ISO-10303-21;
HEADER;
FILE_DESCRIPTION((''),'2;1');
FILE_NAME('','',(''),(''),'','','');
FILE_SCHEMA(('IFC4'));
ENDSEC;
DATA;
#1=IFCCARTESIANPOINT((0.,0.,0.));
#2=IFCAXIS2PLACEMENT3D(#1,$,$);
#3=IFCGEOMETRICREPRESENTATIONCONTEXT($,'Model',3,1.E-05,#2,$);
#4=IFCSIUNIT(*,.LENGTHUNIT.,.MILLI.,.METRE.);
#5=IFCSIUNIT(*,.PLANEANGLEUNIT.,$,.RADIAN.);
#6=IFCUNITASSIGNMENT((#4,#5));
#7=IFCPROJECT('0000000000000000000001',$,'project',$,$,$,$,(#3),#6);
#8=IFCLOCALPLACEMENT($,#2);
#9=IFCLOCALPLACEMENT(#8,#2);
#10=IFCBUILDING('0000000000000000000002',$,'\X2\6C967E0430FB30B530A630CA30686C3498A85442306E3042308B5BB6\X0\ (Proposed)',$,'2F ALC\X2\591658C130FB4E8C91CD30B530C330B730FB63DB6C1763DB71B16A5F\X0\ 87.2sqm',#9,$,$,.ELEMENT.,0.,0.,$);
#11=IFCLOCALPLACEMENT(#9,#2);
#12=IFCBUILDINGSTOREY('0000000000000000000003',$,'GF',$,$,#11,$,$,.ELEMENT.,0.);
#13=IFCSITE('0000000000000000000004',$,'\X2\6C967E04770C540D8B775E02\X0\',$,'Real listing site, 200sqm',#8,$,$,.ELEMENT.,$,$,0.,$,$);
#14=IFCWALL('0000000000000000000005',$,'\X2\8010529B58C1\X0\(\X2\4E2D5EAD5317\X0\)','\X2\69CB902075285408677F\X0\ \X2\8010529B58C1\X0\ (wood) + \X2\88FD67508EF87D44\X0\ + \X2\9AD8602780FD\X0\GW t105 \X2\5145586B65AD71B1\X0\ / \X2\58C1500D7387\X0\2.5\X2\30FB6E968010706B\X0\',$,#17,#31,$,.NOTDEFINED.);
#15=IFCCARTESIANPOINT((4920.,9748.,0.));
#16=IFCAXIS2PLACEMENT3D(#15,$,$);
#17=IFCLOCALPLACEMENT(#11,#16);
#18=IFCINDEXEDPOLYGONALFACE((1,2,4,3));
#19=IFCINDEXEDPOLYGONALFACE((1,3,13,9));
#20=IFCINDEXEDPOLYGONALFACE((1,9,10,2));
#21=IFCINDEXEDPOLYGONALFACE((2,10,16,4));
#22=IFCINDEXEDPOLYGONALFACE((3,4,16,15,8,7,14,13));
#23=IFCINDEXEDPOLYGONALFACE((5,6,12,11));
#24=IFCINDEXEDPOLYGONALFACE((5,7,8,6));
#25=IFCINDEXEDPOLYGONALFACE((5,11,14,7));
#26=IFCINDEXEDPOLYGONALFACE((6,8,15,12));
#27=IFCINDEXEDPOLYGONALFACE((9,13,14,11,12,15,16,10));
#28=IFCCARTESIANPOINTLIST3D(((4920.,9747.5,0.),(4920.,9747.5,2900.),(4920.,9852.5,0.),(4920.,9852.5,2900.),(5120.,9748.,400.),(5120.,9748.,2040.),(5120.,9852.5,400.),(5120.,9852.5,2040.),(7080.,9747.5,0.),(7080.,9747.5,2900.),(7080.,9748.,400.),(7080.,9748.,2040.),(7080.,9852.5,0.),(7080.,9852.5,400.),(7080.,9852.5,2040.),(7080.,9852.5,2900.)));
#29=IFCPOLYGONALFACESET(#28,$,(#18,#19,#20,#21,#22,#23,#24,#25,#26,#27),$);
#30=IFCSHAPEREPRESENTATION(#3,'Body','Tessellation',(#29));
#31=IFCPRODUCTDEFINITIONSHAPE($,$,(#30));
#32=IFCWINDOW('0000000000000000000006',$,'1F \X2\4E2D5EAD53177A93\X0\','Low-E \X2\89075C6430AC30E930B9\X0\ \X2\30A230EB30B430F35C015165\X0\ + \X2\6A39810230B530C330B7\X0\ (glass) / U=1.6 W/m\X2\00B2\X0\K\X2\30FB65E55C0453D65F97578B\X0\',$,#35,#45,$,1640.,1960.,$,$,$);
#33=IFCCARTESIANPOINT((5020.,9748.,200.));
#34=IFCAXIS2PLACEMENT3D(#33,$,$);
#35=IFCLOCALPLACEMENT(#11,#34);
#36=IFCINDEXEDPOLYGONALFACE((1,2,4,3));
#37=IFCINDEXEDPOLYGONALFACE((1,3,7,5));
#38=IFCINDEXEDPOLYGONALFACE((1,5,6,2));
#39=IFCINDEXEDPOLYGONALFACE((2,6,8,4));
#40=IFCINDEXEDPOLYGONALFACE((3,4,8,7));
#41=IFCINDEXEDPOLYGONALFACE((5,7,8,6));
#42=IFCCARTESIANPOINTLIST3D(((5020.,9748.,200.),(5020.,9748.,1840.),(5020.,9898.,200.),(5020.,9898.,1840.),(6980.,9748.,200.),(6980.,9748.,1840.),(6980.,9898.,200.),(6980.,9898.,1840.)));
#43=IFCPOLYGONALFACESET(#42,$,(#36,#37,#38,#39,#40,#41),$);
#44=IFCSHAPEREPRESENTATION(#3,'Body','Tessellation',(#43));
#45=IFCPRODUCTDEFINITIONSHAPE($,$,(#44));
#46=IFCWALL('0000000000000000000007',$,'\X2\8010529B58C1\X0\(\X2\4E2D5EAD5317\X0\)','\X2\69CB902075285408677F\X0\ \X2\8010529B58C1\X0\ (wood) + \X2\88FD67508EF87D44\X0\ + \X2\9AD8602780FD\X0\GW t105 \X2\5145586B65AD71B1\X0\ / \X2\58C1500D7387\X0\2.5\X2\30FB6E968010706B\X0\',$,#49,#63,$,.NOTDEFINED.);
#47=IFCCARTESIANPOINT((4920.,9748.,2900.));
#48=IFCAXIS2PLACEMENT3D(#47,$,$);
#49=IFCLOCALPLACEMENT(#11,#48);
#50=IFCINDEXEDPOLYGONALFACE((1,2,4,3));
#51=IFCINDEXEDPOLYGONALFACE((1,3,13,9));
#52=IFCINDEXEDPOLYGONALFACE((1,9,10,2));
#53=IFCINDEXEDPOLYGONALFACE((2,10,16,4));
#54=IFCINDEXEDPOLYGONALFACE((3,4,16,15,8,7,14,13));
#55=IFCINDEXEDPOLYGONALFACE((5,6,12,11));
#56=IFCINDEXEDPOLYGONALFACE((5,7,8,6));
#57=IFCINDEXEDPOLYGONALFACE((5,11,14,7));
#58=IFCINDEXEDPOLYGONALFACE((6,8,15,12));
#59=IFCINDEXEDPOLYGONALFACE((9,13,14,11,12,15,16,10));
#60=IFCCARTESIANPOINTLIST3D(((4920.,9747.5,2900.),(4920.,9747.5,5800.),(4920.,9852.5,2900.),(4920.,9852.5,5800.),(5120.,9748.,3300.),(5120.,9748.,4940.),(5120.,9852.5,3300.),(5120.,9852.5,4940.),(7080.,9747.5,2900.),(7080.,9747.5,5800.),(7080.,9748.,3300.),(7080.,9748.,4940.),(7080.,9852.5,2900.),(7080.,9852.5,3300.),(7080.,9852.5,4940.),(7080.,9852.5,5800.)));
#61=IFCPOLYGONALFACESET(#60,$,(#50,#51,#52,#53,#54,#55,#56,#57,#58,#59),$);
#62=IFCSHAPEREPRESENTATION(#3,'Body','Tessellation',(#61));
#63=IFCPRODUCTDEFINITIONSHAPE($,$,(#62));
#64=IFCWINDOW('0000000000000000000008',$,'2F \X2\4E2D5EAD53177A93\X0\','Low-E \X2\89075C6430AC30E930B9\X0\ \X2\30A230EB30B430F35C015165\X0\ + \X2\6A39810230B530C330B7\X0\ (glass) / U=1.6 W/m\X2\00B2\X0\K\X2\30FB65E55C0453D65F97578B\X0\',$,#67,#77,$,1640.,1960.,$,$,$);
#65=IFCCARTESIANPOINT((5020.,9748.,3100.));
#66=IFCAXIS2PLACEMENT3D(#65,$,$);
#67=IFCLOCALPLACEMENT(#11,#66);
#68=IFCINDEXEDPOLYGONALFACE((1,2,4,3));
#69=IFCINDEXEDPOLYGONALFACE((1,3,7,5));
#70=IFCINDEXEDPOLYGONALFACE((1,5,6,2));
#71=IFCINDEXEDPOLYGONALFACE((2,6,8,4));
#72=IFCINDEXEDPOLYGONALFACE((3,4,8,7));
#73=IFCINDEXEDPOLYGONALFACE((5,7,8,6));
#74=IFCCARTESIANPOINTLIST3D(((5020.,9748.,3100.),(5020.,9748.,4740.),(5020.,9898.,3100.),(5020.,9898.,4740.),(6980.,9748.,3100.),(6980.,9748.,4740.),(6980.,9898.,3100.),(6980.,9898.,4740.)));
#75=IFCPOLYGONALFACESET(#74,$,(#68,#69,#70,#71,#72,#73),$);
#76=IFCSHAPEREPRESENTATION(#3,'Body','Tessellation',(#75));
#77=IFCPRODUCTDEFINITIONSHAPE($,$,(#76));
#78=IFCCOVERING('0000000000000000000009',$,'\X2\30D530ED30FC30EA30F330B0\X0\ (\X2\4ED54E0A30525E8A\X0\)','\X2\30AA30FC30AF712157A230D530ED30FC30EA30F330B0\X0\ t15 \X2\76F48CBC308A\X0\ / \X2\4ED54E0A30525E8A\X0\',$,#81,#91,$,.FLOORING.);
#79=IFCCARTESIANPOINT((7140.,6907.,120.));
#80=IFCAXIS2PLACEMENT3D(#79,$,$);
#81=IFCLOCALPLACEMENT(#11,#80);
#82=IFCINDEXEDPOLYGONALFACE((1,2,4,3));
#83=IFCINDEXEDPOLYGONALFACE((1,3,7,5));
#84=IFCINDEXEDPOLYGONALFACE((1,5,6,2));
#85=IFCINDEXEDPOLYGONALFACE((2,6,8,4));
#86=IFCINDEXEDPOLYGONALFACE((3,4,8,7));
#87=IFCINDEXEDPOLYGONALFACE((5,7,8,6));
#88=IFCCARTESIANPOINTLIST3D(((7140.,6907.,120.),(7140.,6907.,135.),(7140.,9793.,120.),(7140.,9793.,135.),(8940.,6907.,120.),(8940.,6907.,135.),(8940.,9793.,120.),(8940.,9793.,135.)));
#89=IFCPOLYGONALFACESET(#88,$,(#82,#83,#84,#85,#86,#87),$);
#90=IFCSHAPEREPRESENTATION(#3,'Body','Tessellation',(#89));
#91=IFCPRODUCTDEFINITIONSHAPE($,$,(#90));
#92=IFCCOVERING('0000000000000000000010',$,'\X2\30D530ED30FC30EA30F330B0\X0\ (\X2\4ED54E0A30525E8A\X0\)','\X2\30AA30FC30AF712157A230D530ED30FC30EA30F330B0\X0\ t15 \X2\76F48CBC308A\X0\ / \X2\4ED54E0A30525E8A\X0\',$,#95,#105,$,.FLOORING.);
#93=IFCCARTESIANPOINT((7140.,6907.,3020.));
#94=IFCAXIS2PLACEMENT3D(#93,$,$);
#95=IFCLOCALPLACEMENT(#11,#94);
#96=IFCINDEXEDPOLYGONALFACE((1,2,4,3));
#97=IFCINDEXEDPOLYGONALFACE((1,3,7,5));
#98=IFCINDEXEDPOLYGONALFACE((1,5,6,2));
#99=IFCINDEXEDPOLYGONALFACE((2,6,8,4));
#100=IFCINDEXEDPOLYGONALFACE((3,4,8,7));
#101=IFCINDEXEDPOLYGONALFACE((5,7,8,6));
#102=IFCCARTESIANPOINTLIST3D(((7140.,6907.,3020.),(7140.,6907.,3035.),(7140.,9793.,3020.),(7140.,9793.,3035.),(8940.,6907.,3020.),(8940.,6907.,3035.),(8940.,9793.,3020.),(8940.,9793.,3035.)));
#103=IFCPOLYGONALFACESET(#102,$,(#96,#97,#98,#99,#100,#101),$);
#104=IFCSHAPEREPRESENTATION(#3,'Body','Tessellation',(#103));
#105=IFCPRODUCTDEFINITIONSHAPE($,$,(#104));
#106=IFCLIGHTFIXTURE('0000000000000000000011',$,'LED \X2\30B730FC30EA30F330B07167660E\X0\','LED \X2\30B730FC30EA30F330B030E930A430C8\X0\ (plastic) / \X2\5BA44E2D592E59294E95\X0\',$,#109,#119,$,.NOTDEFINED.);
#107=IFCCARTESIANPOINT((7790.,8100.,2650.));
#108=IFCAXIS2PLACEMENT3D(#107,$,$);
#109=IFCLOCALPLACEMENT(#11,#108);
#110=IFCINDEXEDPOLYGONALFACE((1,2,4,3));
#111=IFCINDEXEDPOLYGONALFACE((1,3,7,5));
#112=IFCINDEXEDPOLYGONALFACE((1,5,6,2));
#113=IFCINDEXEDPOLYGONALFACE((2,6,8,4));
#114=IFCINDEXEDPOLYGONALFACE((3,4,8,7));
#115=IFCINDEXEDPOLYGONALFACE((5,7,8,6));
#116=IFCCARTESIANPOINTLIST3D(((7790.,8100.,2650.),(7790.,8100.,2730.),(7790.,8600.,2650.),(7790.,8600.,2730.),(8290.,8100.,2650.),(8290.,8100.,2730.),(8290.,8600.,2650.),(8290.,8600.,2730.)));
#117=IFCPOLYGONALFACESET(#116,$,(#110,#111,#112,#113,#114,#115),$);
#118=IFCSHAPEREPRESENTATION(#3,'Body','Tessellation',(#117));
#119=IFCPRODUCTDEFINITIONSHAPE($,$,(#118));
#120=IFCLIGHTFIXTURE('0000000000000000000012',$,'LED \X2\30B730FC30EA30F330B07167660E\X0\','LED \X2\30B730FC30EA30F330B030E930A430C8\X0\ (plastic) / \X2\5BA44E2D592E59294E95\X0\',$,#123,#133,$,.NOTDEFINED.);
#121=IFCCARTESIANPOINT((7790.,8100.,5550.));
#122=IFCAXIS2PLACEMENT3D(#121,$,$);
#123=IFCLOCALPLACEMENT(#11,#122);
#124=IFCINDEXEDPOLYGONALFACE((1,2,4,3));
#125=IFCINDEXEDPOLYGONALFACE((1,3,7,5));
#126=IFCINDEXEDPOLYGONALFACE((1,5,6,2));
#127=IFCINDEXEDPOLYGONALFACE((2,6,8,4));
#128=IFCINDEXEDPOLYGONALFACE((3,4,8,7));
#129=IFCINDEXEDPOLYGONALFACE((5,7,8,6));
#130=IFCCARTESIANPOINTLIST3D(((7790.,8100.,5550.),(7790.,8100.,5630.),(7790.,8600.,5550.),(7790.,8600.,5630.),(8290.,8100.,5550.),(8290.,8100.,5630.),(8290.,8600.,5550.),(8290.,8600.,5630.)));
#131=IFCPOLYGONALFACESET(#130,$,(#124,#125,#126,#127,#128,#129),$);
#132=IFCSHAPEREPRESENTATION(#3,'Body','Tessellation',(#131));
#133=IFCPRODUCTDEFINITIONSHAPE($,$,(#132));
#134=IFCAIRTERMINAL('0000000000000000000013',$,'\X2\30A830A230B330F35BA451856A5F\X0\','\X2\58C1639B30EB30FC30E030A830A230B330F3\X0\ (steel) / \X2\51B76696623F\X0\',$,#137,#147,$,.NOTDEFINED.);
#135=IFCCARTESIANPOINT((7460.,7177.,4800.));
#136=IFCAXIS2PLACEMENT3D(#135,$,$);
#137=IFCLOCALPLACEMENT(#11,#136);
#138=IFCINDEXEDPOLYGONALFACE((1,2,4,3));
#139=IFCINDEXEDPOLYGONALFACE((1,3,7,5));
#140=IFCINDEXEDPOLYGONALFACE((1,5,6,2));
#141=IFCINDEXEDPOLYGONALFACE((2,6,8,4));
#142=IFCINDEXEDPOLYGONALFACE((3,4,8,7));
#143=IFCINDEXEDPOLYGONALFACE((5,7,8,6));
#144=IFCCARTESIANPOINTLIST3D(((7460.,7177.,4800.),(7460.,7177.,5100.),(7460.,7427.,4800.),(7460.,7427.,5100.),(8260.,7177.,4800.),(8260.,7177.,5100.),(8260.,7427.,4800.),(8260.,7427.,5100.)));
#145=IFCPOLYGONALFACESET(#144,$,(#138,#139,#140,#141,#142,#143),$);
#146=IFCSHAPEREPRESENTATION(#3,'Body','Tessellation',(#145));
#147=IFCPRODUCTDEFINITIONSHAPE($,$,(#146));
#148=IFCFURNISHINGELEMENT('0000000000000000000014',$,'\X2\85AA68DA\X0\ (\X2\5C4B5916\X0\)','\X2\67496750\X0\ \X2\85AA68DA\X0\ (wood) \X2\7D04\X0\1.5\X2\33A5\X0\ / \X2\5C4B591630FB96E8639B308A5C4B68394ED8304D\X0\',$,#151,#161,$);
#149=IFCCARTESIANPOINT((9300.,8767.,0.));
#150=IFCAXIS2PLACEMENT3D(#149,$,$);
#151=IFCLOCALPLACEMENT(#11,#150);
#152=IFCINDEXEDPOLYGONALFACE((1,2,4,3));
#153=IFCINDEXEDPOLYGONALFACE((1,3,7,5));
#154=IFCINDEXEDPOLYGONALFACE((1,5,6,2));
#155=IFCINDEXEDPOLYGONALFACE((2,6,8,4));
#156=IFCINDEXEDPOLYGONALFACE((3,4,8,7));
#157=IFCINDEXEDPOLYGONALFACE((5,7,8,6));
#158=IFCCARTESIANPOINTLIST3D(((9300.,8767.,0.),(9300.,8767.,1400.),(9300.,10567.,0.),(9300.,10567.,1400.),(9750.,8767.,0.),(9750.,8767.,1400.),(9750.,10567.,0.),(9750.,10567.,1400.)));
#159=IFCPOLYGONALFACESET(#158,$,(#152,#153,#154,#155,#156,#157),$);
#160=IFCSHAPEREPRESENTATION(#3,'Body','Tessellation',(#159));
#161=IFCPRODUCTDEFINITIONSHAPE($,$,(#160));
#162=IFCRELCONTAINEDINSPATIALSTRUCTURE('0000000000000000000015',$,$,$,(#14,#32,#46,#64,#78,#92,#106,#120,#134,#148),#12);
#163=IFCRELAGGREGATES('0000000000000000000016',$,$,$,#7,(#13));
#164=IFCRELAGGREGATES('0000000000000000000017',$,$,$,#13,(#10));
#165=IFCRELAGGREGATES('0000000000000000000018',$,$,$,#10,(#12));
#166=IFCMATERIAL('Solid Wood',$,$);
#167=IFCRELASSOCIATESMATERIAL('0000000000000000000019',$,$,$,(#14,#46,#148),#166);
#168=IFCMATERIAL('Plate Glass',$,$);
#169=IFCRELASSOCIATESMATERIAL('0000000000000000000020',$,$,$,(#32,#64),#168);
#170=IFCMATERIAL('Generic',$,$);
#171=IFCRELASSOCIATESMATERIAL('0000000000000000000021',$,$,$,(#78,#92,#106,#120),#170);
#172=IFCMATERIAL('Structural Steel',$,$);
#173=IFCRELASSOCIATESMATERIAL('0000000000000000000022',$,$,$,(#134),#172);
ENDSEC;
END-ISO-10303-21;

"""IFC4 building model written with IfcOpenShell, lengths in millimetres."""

from ifc_helpers import new_model, si_unit, frame, frame_2d, origin, place, context, project, spatial, rectangle, extrude, material, element, fill, save


model = new_model("IFC4")

# Units and contexts
model_context = context("Model", 3, precision=1e-05, world=origin())
ifc_project = project(units=[si_unit("LENGTHUNIT", "METRE", prefix="MILLI"), si_unit("PLANEANGLEUNIT", "RADIAN")], contexts=[model_context])

# Site, building, storey
site_placement = place(None, origin())
site = spatial("IfcSite", under=ifc_project, at=site_placement, Name="沖縄県名護市", ObjectType="Real listing site, 200sqm", CompositionType="ELEMENT", RefElevation=0.0)
building_placement = place(site_placement, origin())
building = spatial("IfcBuilding", under=site, at=building_placement, Name="沖縄・サウナと水風呂のある家 (Proposed)", ObjectType="2F ALC外壁・二重サッシ・換気換熱機 87.2sqm", CompositionType="ELEMENT", ElevationOfRefHeight=0.0, ElevationOfTerrain=0.0)
storey_placement = place(building_placement, origin())
storey = spatial("IfcBuildingStorey", under=building, at=storey_placement, Name="GF", CompositionType="ELEMENT", Elevation=0.0)

# Shared definitions
ifc_material_1 = material(Name="Solid Wood")

# Walls, openings, windows
wall_1_placement = place(storey_placement, frame((4920.0, 9748.0, 0.0)))
wall_1 = element("IfcWall", 1, at=wall_1_placement, inside=storey, material=ifc_material_1, Name="耐力壁(中庭北)", Description="構造用合板 耐力壁 (wood) + 製材軸組 + 高性能GW t105 充填断熱 / 壁倍率2.5・準耐火", PredefinedType="NOTDEFINED", context=model_context, shape_type="SweptSolid", body=[
    extrude(rectangle(XDim=2160.0, YDim=105.0, at=frame_2d((1080.0, 52.0))), frame((4920.0, 9748.0, 0.0)), (0.0, 0.0, 1.0), 2900.0),
])
opening_1_placement = place(storey_placement, frame((5020.0, 9748.0, 200.0)))
opening_1 = element("IfcOpeningElement", 2, at=opening_1_placement, cuts=wall_1, PredefinedType="NOTDEFINED", context=model_context, shape_type="SweptSolid", body=[
    extrude(rectangle(XDim=1960.0, YDim=150.0, at=frame_2d((980.0, 75.0))), frame((5020.0, 9748.0, 200.0)), (0.0, 0.0, 1.0), 1640.0),
])
ifc_material_2 = material(Name="Plate Glass")
window_1_placement = place(storey_placement, frame((5020.0, 9748.0, 200.0)))
window_1 = element("IfcWindow", 3, at=window_1_placement, inside=storey, material=ifc_material_2, Name="1F 中庭北窓", Description="Low-E 複層ガラス アルゴン封入 + 樹脂サッシ (glass) / U=1.6 W/m²K・日射取得型", OverallHeight=1640.0, OverallWidth=1960.0, context=model_context, shape_type="SweptSolid", body=[
    extrude(rectangle(XDim=1960.0, YDim=150.0, at=frame_2d((980.0, 75.0))), frame((5020.0, 9748.0, 200.0)), (0.0, 0.0, 1.0), 1640.0),
])
fill(opening_1, window_1)
wall_2_placement = place(storey_placement, frame((4920.0, 9748.0, 2900.0)))
wall_2 = element("IfcWall", 4, at=wall_2_placement, inside=storey, material=ifc_material_1, Name="耐力壁(中庭北)", Description="構造用合板 耐力壁 (wood) + 製材軸組 + 高性能GW t105 充填断熱 / 壁倍率2.5・準耐火", PredefinedType="NOTDEFINED", context=model_context, shape_type="SweptSolid", body=[
    extrude(rectangle(XDim=2160.0, YDim=105.0, at=frame_2d((1080.0, 52.0))), frame((4920.0, 9748.0, 2900.0)), (0.0, 0.0, 1.0), 2900.0),
])
opening_2_placement = place(storey_placement, frame((5020.0, 9748.0, 3100.0)))
opening_2 = element("IfcOpeningElement", 5, at=opening_2_placement, cuts=wall_2, PredefinedType="NOTDEFINED", context=model_context, shape_type="SweptSolid", body=[
    extrude(rectangle(XDim=1960.0, YDim=150.0, at=frame_2d((980.0, 75.0))), frame((5020.0, 9748.0, 3100.0)), (0.0, 0.0, 1.0), 1640.0),
])
window_2_placement = place(storey_placement, frame((5020.0, 9748.0, 3100.0)))
window_2 = element("IfcWindow", 6, at=window_2_placement, inside=storey, material=ifc_material_2, Name="2F 中庭北窓", Description="Low-E 複層ガラス アルゴン封入 + 樹脂サッシ (glass) / U=1.6 W/m²K・日射取得型", OverallHeight=1640.0, OverallWidth=1960.0, context=model_context, shape_type="SweptSolid", body=[
    extrude(rectangle(XDim=1960.0, YDim=150.0, at=frame_2d((980.0, 75.0))), frame((5020.0, 9748.0, 3100.0)), (0.0, 0.0, 1.0), 1640.0),
])
fill(opening_2, window_2)

# Coverings
ifc_material_3 = material(Name="Generic")
covering_1_placement = place(storey_placement, frame((7140.0, 6907.0, 120.0)))
element("IfcCovering", 7, at=covering_1_placement, inside=storey, material=ifc_material_3, Name="フローリング (仕上げ床)", Description="オーク無垢フローリング t15 直貼り / 仕上げ床", PredefinedType="FLOORING", context=model_context, shape_type="SweptSolid", body=[
    extrude(rectangle(XDim=1800.0, YDim=2886.0, at=frame_2d((900.0, 1443.0))), frame((7140.0, 6907.0, 120.0)), (0.0, 0.0, 1.0), 15.0),
])
covering_2_placement = place(storey_placement, frame((7140.0, 6907.0, 3020.0)))
element("IfcCovering", 8, at=covering_2_placement, inside=storey, material=ifc_material_3, Name="フローリング (仕上げ床)", Description="オーク無垢フローリング t15 直貼り / 仕上げ床", PredefinedType="FLOORING", context=model_context, shape_type="SweptSolid", body=[
    extrude(rectangle(XDim=1800.0, YDim=2886.0, at=frame_2d((900.0, 1443.0))), frame((7140.0, 6907.0, 3020.0)), (0.0, 0.0, 1.0), 15.0),
])

# Light fixtures
light_fixture_1_placement = place(storey_placement, frame((7790.0, 8100.0, 2650.0)))
element("IfcLightFixture", 9, at=light_fixture_1_placement, inside=storey, material=ifc_material_3, Name="LED シーリング照明", Description="LED シーリングライト (plastic) / 室中央天井", PredefinedType="NOTDEFINED", context=model_context, shape_type="SweptSolid", body=[
    extrude(rectangle(XDim=500.0, YDim=500.0, at=frame_2d((250.0, 250.0))), frame((7790.0, 8100.0, 2650.0)), (0.0, 0.0, 1.0), 80.0),
])
light_fixture_2_placement = place(storey_placement, frame((7790.0, 8100.0, 5550.0)))
element("IfcLightFixture", 10, at=light_fixture_2_placement, inside=storey, material=ifc_material_3, Name="LED シーリング照明", Description="LED シーリングライト (plastic) / 室中央天井", PredefinedType="NOTDEFINED", context=model_context, shape_type="SweptSolid", body=[
    extrude(rectangle(XDim=500.0, YDim=500.0, at=frame_2d((250.0, 250.0))), frame((7790.0, 8100.0, 5550.0)), (0.0, 0.0, 1.0), 80.0),
])

# Air terminal
ifc_material_4 = material(Name="Structural Steel")
air_terminal_placement = place(storey_placement, frame((7460.0, 7177.0, 4800.0)))
element("IfcAirTerminal", 11, at=air_terminal_placement, inside=storey, material=ifc_material_4, Name="エアコン室内機", Description="壁掛ルームエアコン (steel) / 冷暖房", PredefinedType="NOTDEFINED", context=model_context, shape_type="SweptSolid", body=[
    extrude(rectangle(XDim=800.0, YDim=250.0, at=frame_2d((400.0, 125.0))), frame((7460.0, 7177.0, 4800.0)), (0.0, 0.0, 1.0), 300.0),
])

# Furnishing element
furnishing_placement = place(storey_placement, frame((9300.0, 8767.0, 0.0)))
element("IfcFurnishingElement", 12, at=furnishing_placement, inside=storey, material=ifc_material_1, Name="薪棚 (屋外)", Description="杉材 薪棚 (wood) 約1.5㎥ / 屋外・雨掛り屋根付き", context=model_context, shape_type="SweptSolid", body=[
    extrude(rectangle(XDim=450.0, YDim=1800.0, at=frame_2d((225.0, 900.0))), frame((9300.0, 8767.0, 0.0)), (0.0, 0.0, 1.0), 1400.0),
])

save(model, "model.ifc")
